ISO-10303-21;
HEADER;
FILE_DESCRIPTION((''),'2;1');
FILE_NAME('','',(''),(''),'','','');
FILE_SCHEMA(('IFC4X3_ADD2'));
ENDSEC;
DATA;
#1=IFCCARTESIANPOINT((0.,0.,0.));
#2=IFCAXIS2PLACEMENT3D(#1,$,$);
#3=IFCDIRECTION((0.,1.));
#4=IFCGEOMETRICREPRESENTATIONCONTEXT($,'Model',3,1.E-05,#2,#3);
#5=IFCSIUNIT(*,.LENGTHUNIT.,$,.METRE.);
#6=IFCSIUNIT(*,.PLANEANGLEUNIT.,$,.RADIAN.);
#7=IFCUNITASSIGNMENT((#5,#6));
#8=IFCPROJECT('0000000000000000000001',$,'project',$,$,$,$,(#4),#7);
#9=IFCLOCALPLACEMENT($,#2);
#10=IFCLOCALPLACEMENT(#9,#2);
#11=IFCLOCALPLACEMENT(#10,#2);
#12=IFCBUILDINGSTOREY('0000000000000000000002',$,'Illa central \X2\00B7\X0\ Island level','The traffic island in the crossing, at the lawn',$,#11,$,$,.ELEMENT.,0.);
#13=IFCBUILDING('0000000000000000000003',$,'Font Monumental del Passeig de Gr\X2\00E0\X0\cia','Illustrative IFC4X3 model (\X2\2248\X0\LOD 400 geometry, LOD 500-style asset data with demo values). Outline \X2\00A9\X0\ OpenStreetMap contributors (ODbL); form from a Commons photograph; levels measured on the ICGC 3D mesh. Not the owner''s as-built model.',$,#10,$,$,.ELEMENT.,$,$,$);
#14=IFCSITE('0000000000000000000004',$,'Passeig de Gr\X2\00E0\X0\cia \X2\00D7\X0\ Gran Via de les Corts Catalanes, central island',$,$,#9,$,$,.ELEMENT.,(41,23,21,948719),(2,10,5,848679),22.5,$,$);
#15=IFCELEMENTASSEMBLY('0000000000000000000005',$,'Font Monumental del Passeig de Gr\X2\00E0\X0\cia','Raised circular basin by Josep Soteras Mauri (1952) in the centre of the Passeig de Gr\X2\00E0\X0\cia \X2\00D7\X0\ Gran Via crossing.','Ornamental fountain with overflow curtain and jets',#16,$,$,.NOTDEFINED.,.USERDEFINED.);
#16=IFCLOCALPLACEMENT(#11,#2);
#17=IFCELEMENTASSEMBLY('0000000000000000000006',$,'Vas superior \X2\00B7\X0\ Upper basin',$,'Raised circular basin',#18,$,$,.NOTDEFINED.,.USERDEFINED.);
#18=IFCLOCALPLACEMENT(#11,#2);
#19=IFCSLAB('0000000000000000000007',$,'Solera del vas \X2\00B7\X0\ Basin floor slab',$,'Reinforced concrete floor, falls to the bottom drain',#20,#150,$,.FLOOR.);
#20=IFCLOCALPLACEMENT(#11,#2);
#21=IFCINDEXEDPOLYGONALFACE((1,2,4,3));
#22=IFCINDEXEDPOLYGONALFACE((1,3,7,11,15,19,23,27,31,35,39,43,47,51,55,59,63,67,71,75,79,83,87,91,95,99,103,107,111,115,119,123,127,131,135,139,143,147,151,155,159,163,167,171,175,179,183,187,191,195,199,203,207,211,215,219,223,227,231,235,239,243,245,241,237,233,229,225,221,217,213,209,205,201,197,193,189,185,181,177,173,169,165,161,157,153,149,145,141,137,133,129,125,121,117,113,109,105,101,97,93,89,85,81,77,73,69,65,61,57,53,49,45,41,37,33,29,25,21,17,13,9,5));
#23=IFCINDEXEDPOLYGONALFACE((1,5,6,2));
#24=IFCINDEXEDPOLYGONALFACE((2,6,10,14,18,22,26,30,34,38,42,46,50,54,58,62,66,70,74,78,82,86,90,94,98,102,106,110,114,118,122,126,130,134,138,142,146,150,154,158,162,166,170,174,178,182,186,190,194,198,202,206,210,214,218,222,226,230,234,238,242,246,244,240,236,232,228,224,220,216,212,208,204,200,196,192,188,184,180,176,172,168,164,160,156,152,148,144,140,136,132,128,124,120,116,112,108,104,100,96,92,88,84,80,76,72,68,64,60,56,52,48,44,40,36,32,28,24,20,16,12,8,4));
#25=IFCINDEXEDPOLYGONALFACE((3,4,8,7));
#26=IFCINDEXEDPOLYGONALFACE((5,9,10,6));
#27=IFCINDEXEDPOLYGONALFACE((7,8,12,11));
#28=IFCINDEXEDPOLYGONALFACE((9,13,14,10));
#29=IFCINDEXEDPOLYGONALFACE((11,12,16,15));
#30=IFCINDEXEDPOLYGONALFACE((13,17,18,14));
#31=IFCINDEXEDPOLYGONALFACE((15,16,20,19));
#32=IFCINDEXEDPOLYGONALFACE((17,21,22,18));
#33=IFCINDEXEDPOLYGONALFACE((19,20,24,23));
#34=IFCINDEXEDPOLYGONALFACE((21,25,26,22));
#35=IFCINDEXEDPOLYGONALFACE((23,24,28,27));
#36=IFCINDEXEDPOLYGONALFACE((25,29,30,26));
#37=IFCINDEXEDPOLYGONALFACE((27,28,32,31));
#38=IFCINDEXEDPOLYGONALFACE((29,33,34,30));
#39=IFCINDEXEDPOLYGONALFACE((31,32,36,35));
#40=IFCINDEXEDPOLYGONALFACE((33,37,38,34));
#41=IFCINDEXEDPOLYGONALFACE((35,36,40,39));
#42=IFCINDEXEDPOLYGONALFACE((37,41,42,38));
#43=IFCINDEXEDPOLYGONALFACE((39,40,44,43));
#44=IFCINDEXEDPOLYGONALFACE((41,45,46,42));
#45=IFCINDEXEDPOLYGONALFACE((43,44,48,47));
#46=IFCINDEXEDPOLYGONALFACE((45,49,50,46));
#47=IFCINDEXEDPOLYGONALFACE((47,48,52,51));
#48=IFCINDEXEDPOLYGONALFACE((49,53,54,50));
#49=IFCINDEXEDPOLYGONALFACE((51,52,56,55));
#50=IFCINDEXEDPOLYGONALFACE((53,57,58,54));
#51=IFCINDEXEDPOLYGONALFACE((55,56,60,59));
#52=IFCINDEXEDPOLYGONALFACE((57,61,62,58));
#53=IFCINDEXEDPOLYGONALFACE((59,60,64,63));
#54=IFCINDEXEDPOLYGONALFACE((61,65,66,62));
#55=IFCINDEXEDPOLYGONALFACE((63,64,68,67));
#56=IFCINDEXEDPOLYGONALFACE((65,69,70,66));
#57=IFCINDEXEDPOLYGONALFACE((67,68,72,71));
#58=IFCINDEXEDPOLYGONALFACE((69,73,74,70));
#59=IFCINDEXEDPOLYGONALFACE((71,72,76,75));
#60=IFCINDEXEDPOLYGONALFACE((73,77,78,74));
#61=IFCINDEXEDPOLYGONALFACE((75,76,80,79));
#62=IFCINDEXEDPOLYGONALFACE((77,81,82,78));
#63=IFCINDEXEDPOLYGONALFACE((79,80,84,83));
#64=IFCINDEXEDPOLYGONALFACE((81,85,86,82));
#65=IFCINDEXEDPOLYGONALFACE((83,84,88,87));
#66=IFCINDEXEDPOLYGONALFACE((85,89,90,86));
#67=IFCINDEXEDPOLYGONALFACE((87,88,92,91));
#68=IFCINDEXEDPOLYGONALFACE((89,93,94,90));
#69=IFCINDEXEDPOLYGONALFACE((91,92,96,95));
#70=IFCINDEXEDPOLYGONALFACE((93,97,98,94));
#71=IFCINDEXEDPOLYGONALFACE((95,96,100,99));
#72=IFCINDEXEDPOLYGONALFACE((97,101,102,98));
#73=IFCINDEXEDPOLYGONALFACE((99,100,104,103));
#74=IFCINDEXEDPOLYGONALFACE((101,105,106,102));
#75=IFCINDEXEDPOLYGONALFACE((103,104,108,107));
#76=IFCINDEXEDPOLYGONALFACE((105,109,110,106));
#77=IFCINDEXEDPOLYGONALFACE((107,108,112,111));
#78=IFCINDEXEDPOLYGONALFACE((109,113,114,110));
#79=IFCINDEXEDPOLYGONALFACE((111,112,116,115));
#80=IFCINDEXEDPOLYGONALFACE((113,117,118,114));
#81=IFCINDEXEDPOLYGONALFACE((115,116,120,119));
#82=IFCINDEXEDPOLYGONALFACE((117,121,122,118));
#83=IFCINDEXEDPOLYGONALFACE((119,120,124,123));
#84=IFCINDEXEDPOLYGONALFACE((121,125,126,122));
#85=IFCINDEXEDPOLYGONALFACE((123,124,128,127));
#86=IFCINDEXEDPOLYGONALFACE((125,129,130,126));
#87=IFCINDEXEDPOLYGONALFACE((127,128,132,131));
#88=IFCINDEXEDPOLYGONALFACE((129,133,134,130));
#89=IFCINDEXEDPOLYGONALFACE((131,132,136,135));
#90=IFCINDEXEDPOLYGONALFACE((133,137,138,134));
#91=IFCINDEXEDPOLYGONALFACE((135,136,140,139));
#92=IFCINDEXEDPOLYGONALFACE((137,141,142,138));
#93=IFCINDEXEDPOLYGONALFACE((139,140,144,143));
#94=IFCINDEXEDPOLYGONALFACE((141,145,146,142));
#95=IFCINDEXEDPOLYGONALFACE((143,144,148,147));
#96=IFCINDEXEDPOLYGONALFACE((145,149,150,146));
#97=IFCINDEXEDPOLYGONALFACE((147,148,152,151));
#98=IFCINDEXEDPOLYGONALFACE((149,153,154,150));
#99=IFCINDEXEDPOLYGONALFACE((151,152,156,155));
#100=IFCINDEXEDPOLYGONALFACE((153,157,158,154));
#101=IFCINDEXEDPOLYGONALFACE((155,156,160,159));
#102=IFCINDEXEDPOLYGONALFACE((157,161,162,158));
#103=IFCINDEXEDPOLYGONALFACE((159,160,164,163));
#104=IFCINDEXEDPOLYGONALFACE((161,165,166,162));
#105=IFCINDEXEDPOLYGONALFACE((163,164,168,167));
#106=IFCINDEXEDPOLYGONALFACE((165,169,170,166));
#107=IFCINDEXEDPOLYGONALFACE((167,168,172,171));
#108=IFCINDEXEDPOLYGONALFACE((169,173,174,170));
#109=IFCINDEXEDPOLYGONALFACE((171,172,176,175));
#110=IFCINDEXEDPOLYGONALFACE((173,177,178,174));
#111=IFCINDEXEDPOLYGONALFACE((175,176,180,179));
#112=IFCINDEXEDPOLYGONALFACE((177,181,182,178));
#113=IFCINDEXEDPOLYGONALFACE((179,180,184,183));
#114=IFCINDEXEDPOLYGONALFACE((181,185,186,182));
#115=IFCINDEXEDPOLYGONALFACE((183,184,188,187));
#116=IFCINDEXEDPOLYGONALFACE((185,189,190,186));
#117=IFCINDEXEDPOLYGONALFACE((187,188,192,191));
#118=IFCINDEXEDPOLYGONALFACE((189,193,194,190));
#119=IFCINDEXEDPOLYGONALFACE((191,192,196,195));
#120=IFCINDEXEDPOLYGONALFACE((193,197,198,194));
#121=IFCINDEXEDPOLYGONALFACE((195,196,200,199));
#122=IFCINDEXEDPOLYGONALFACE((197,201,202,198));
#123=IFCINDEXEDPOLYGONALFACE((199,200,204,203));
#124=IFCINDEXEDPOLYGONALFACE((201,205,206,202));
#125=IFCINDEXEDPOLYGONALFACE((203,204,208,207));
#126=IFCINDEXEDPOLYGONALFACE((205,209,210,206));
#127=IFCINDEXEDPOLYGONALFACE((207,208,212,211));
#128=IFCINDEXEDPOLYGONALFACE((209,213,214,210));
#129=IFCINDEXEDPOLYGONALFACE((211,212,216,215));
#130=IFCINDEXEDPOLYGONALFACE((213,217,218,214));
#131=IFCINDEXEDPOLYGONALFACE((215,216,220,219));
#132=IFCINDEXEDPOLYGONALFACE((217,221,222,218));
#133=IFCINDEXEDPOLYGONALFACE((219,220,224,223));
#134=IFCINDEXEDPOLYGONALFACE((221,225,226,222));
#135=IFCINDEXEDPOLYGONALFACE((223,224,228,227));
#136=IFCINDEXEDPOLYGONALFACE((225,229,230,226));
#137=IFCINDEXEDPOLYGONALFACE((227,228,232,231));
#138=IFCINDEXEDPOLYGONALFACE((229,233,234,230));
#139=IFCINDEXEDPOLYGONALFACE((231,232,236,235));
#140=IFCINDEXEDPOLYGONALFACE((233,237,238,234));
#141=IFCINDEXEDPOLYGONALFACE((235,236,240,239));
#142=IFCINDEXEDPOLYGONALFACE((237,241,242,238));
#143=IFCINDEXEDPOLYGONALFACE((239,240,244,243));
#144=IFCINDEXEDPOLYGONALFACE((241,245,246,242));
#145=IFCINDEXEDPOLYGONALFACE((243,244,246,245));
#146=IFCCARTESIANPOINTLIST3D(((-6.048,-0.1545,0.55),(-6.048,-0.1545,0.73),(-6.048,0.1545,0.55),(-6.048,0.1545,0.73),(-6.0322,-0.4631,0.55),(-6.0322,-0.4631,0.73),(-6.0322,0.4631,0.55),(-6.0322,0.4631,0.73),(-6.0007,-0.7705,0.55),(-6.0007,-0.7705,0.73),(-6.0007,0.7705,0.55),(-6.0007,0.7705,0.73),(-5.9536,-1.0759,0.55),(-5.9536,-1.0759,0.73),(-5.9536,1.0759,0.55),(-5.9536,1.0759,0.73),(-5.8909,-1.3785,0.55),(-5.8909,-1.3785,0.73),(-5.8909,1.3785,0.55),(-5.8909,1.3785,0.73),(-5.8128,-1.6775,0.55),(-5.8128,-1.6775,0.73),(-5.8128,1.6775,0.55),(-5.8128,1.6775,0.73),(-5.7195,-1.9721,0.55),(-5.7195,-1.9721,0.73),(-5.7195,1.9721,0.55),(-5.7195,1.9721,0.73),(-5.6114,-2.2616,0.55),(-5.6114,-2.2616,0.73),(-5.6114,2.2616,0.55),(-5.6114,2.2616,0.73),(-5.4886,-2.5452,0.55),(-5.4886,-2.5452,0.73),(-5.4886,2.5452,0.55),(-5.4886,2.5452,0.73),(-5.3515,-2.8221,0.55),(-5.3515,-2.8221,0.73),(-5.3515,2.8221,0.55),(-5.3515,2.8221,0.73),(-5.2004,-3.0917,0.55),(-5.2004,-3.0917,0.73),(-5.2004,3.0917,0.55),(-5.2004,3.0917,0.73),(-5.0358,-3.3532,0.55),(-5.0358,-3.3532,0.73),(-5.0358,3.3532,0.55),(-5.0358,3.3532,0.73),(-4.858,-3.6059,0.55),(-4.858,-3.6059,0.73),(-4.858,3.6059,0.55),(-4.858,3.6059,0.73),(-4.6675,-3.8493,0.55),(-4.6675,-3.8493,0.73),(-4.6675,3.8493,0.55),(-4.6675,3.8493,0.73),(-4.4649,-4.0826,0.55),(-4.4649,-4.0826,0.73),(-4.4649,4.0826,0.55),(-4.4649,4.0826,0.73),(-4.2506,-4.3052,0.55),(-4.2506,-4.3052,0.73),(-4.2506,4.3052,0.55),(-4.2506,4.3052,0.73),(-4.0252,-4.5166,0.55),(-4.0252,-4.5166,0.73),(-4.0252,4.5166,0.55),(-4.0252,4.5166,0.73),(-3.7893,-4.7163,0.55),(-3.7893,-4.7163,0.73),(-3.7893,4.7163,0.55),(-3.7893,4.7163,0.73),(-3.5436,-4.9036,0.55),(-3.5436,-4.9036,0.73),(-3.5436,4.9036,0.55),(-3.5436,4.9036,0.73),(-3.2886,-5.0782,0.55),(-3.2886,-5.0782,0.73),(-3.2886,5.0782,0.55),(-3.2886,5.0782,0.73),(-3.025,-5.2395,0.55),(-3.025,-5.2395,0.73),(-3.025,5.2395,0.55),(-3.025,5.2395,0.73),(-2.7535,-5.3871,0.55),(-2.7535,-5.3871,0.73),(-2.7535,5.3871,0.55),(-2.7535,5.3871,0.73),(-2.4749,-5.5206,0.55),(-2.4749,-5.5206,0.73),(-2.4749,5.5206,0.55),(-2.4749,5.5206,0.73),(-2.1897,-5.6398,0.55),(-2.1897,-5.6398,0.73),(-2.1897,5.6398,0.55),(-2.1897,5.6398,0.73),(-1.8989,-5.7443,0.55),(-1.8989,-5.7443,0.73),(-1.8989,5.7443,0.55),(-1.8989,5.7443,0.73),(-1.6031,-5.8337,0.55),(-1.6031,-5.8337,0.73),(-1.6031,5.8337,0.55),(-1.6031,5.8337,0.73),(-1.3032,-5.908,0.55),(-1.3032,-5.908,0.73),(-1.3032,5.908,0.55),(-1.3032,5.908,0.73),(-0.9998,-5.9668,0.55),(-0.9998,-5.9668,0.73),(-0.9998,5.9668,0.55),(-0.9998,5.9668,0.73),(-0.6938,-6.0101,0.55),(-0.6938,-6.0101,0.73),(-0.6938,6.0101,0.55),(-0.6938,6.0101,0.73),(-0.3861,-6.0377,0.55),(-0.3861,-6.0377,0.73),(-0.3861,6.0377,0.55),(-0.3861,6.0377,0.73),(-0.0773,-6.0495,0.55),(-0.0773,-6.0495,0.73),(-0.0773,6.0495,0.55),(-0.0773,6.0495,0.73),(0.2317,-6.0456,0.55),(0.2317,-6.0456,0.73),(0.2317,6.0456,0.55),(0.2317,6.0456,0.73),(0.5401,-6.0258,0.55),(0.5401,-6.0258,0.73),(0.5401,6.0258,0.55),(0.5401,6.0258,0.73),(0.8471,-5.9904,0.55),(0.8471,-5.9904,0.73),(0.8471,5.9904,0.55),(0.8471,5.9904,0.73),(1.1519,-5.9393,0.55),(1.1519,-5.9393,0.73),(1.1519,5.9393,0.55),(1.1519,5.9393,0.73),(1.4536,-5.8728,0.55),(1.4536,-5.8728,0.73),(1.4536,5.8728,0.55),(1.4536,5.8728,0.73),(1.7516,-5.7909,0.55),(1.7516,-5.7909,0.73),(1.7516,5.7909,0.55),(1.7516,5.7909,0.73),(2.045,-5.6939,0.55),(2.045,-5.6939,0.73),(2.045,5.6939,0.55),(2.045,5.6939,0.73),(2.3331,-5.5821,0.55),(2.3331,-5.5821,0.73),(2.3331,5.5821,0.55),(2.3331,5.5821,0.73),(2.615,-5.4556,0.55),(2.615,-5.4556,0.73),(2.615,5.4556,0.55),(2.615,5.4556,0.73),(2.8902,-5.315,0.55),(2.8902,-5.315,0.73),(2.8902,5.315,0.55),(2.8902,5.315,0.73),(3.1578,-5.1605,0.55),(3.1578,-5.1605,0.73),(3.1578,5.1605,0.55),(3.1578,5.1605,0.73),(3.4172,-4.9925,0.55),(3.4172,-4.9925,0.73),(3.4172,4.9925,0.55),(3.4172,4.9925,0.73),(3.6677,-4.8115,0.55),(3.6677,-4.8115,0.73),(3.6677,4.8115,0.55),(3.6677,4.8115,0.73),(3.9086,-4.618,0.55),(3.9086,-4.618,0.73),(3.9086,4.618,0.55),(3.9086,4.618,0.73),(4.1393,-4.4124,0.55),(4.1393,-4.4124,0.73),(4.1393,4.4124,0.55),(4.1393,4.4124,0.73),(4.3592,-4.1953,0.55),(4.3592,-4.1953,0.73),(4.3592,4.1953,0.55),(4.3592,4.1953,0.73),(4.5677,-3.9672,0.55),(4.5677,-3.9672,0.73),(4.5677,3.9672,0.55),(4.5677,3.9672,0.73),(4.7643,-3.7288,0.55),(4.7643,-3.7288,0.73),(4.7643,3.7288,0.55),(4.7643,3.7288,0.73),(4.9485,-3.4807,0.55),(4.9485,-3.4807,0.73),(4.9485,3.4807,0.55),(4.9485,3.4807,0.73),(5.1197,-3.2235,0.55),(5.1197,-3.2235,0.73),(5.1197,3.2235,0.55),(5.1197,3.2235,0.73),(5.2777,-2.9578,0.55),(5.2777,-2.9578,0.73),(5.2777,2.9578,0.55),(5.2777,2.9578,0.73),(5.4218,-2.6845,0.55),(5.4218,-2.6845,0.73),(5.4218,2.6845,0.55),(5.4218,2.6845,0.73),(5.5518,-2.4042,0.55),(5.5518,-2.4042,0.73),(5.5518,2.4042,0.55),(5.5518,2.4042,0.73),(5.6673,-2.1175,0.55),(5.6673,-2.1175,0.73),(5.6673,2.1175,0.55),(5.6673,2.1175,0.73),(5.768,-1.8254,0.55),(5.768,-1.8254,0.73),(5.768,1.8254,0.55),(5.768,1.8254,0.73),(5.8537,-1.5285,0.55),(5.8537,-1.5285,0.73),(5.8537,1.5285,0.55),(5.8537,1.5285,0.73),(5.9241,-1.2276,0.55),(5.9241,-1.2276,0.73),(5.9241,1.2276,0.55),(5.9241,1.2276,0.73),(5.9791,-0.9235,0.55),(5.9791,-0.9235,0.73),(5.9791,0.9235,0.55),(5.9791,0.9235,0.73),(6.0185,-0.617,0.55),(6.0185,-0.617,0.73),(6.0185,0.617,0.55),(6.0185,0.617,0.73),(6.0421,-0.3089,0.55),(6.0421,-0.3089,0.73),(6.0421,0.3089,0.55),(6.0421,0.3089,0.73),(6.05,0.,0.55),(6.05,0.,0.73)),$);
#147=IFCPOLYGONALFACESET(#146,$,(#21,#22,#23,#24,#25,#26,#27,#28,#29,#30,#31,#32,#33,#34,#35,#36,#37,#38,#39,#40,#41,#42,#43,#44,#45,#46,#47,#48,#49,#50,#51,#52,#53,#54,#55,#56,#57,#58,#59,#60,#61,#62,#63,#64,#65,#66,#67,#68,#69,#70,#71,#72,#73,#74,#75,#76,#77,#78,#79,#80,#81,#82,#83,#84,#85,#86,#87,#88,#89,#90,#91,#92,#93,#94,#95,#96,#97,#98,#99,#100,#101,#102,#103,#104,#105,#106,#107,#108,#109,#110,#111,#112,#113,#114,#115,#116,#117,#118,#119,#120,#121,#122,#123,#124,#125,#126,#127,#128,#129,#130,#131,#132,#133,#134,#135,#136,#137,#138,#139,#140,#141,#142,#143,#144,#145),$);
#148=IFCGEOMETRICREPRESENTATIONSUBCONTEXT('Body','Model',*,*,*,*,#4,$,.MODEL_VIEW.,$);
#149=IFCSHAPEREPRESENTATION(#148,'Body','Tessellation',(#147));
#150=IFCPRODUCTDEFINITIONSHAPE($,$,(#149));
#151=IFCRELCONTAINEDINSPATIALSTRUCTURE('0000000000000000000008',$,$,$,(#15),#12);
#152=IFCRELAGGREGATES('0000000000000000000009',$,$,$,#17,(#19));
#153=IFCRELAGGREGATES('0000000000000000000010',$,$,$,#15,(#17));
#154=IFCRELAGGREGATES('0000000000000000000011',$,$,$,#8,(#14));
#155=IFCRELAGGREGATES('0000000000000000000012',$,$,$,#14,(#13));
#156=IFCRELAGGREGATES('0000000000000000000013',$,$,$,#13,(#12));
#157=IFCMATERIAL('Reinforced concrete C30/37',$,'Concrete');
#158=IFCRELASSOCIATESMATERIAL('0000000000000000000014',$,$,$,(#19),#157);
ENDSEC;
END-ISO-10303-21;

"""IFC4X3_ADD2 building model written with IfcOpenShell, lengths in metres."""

from ifc_helpers import new_model, si_unit, direction, frame, origin, origin_2d_with_axis, place, context, subcontext, project, spatial, circle, extrude, material, element, aggregate, save


model = new_model("IFC4X3_ADD2")

# Units and contexts
model_context = context("Model", 3, precision=1e-05, world=origin(), true_north=direction((0.0, 1.0)))
body_context = subcontext(model_context, "Body", "Model", "MODEL_VIEW")
ifc_project = project(units=[si_unit("LENGTHUNIT", "METRE"), si_unit("PLANEANGLEUNIT", "RADIAN")], contexts=[model_context])

# Site, building, storey
site_placement = place(None, origin())
site = spatial("IfcSite", under=ifc_project, at=site_placement, Name="Passeig de Gràcia × Gran Via de les Corts Catalanes, central island", CompositionType="ELEMENT", RefLatitude=(41, 23, 21, 948719), RefLongitude=(2, 10, 5, 848679), RefElevation=22.5)
building_placement = place(site_placement, origin())
building = spatial("IfcBuilding", under=site, at=building_placement, Name="Font Monumental del Passeig de Gràcia", Description="Illustrative IFC4X3 model (≈LOD 400 geometry, LOD 500-style asset data with demo values). Outline © OpenStreetMap contributors (ODbL); form from a Commons photograph; levels measured on the ICGC 3D mesh. Not the owner's as-built model.", CompositionType="ELEMENT")
storey_placement = place(building_placement, origin())
storey = spatial("IfcBuildingStorey", under=building, at=storey_placement, Name="Illa central · Island level", Description="The traffic island in the crossing, at the lawn", CompositionType="ELEMENT", Elevation=0.0)

# Element assemblies, slab
assembly_1_placement = place(building_placement, origin())
assembly_1 = element("IfcElementAssembly", 1, at=assembly_1_placement, inside=storey, Name="Font Monumental del Passeig de Gràcia", Description="Raised circular basin by Josep Soteras Mauri (1952) in the centre of the Passeig de Gràcia × Gran Via crossing.", ObjectType="Ornamental fountain with overflow curtain and jets", AssemblyPlace="NOTDEFINED", PredefinedType="USERDEFINED")
assembly_2_placement = place(building_placement, origin())
assembly_2 = element("IfcElementAssembly", 2, at=assembly_2_placement, Name="Vas superior · Upper basin", ObjectType="Raised circular basin", AssemblyPlace="NOTDEFINED", PredefinedType="USERDEFINED")
ifc_material_1 = material(Name="Reinforced concrete C30/37", Category="Concrete")
slab_1_placement = place(building_placement, origin())
slab_1 = element("IfcSlab", 3, at=slab_1_placement, material=ifc_material_1, Name="Solera del vas · Basin floor slab", ObjectType="Reinforced concrete floor, falls to the bottom drain", PredefinedType="FLOOR", context=body_context, shape_type="SweptSolid", body=[
    extrude(circle(Radius=6.05, at=origin_2d_with_axis()), frame((0.0, 0.0, 0.55)), (0.0, 0.0, 1.0), 0.18),
])
aggregate(assembly_2, [slab_1])
aggregate(assembly_1, [assembly_2])

save(model, "model.ifc")
